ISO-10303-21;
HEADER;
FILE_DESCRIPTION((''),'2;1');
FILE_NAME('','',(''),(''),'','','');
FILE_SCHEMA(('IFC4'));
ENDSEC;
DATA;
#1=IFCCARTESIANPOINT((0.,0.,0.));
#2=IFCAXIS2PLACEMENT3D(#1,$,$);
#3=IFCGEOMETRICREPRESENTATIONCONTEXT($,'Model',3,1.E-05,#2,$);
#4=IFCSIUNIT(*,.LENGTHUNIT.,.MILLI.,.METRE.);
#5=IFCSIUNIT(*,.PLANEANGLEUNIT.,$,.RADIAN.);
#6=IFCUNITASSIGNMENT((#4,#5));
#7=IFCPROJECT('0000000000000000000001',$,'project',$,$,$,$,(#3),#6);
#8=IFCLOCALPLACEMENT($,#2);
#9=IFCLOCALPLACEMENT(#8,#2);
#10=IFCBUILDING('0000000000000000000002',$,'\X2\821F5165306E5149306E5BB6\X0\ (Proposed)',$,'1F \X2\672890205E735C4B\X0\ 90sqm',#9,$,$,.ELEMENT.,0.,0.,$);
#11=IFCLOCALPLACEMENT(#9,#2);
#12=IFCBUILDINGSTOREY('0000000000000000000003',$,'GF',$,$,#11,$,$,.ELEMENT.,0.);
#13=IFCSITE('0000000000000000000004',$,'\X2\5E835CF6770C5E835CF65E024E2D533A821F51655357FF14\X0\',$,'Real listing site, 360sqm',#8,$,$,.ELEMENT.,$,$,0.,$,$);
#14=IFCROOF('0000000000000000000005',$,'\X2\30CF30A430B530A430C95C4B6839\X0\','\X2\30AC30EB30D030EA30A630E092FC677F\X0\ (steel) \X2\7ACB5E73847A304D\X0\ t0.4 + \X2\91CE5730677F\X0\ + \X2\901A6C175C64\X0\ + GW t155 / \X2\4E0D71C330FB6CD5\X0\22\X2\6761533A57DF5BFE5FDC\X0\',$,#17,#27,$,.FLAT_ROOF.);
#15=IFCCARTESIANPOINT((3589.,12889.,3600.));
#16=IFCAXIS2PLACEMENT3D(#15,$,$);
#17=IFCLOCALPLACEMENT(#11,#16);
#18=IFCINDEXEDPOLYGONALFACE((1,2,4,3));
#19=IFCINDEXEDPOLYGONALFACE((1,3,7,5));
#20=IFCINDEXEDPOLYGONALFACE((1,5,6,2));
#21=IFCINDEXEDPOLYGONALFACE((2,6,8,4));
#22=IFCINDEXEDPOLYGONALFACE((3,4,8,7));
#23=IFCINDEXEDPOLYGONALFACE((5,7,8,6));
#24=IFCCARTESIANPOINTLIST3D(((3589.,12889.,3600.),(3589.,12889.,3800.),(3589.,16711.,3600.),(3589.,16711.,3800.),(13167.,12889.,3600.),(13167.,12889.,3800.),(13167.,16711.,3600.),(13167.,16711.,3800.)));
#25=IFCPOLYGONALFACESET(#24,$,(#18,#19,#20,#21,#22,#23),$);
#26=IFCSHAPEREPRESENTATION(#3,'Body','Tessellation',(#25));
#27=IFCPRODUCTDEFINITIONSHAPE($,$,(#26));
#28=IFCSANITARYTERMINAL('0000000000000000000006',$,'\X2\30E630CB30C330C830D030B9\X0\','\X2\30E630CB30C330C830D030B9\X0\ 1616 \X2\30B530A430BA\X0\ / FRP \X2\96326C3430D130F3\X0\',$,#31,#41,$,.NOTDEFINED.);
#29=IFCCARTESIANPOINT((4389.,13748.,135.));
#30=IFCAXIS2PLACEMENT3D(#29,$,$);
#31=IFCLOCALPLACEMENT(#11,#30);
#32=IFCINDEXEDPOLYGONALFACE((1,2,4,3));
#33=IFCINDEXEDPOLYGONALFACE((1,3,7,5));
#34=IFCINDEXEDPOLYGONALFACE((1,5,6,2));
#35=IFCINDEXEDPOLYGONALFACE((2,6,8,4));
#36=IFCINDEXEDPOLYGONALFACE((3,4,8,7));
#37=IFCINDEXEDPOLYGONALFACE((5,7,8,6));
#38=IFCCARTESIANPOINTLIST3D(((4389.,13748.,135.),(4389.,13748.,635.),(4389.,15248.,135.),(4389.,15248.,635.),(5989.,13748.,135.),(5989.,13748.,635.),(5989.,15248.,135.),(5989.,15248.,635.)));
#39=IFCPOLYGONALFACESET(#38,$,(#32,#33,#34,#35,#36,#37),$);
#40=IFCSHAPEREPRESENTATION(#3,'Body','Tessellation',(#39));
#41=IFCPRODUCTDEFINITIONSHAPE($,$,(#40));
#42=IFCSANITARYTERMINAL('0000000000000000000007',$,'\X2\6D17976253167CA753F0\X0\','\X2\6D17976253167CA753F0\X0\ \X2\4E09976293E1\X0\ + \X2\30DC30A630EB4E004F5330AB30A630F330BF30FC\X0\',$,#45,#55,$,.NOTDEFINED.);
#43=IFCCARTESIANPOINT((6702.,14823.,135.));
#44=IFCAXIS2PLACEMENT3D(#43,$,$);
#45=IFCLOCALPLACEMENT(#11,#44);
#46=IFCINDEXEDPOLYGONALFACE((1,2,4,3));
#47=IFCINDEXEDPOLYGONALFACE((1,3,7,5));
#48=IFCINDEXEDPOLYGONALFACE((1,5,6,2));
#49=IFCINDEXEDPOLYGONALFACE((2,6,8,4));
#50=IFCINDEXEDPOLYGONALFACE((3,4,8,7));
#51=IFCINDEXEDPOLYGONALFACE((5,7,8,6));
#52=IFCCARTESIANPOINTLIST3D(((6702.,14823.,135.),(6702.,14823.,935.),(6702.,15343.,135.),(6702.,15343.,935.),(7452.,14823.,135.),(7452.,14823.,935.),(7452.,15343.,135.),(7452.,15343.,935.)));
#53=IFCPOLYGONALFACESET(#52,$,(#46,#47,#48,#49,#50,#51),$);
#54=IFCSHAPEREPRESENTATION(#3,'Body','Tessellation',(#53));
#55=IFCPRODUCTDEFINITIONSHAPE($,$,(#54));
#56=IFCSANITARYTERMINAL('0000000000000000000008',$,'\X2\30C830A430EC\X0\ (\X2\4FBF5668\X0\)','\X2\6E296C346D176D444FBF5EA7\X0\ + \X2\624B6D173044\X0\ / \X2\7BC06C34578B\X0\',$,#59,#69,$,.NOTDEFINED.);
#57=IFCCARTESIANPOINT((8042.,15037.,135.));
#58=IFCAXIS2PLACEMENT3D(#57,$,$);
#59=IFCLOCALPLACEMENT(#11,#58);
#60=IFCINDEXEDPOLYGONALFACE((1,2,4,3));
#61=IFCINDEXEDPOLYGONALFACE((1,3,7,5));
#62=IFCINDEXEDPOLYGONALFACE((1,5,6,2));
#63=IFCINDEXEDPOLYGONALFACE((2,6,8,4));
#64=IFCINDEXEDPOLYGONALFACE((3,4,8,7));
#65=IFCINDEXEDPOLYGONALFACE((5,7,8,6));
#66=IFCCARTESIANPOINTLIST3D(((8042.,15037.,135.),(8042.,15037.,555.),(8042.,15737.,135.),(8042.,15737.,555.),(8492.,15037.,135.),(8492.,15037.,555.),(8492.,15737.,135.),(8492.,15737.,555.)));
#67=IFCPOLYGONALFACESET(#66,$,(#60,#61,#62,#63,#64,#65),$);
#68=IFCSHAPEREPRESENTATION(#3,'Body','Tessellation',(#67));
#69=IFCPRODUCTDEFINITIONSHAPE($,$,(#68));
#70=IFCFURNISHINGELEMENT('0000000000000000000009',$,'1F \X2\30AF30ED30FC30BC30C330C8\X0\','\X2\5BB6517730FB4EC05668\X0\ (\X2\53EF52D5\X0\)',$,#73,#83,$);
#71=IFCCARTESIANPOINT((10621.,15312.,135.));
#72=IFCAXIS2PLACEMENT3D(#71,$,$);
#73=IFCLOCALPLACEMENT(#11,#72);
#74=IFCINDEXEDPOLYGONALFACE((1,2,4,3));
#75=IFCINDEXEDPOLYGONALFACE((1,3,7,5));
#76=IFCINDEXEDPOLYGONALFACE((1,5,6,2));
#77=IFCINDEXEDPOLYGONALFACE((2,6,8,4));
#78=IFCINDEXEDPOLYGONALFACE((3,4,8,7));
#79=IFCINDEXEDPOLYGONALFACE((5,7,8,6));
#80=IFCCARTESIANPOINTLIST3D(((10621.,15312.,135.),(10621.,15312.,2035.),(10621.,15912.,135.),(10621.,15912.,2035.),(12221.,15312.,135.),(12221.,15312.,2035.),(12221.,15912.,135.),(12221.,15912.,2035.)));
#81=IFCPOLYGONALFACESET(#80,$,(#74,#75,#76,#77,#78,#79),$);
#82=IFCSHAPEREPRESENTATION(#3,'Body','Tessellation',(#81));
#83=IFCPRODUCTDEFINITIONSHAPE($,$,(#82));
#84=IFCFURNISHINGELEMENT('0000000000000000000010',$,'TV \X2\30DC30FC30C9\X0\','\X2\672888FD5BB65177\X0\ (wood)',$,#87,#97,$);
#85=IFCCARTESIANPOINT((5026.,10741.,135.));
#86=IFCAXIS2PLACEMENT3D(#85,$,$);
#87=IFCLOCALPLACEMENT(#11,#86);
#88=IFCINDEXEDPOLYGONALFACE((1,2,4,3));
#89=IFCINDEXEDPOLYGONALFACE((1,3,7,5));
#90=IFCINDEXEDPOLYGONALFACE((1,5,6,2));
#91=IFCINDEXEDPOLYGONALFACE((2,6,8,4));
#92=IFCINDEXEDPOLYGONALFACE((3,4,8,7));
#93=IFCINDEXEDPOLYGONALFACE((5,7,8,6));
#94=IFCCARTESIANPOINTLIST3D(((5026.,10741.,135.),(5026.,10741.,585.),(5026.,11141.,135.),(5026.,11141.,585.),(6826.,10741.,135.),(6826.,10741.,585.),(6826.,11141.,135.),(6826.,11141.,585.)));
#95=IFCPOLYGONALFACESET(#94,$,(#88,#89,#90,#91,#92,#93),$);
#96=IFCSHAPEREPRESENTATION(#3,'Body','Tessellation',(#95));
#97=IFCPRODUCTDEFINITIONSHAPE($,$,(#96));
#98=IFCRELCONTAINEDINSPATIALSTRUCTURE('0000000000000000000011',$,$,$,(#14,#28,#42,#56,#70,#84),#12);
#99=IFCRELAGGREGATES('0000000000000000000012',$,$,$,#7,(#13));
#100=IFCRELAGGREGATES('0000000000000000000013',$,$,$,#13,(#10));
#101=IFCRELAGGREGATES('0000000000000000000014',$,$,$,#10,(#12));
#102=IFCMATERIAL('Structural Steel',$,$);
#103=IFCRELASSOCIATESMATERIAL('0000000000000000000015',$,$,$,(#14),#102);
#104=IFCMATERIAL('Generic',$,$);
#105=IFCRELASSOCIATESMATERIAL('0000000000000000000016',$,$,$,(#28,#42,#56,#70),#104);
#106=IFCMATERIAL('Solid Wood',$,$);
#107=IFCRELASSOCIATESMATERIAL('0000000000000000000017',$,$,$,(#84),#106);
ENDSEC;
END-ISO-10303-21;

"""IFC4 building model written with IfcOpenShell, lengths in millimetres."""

from ifc_helpers import new_model, si_unit, frame, frame_2d, origin, place, context, project, spatial, rectangle, extrude, material, element, save


model = new_model("IFC4")

# Units and contexts
model_context = context("Model", 3, precision=1e-05, world=origin())
ifc_project = project(units=[si_unit("LENGTHUNIT", "METRE", prefix="MILLI"), si_unit("PLANEANGLEUNIT", "RADIAN")], contexts=[model_context])

# Site, building, storey
site_placement = place(None, origin())
site = spatial("IfcSite", under=ifc_project, at=site_placement, Name="広島県広島市中区舟入南４", ObjectType="Real listing site, 360sqm", CompositionType="ELEMENT", RefElevation=0.0)
building_placement = place(site_placement, origin())
building = spatial("IfcBuilding", under=site, at=building_placement, Name="舟入の光の家 (Proposed)", ObjectType="1F 木造平屋 90sqm", CompositionType="ELEMENT", ElevationOfRefHeight=0.0, ElevationOfTerrain=0.0)
storey_placement = place(building_placement, origin())
storey = spatial("IfcBuildingStorey", under=building, at=storey_placement, Name="GF", CompositionType="ELEMENT", Elevation=0.0)

# Shared definitions
ifc_material_1 = material(Name="Solid Wood")

# Roof
ifc_material_2 = material(Name="Structural Steel")
roof_placement = place(storey_placement, frame((3589.0, 12889.0, 3600.0)))
element("IfcRoof", 1, at=roof_placement, inside=storey, material=ifc_material_2, Name="ハイサイド屋根", Description="ガルバリウム鋼板 (steel) 立平葺き t0.4 + 野地板 + 通気層 + GW t155 / 不燃・法22条区域対応", PredefinedType="FLAT_ROOF", context=model_context, shape_type="SweptSolid", body=[
    extrude(rectangle(XDim=9578.0, YDim=3822.0, at=frame_2d((4789.0, 1911.0))), frame((3589.0, 12889.0, 3600.0)), (0.0, 0.0, 1.0), 200.0),
])

# Sanitary terminals
ifc_material_3 = material(Name="Generic")
sanitary_terminal_1_placement = place(storey_placement, frame((4389.0, 13748.0, 135.0)))
element("IfcSanitaryTerminal", 2, at=sanitary_terminal_1_placement, inside=storey, material=ifc_material_3, Name="ユニットバス", Description="ユニットバス 1616 サイズ / FRP 防水パン", PredefinedType="NOTDEFINED", context=model_context, shape_type="SweptSolid", body=[
    extrude(rectangle(XDim=1600.0, YDim=1500.0, at=frame_2d((800.0, 750.0))), frame((4389.0, 13748.0, 135.0)), (0.0, 0.0, 1.0), 500.0),
])
sanitary_terminal_2_placement = place(storey_placement, frame((6702.0, 14823.0, 135.0)))
element("IfcSanitaryTerminal", 3, at=sanitary_terminal_2_placement, inside=storey, material=ifc_material_3, Name="洗面化粧台", Description="洗面化粧台 三面鏡 + ボウル一体カウンター", PredefinedType="NOTDEFINED", context=model_context, shape_type="SweptSolid", body=[
    extrude(rectangle(XDim=750.0, YDim=520.0, at=frame_2d((375.0, 260.0))), frame((6702.0, 14823.0, 135.0)), (0.0, 0.0, 1.0), 800.0),
])
sanitary_terminal_3_placement = place(storey_placement, frame((8042.0, 15037.0, 135.0)))
element("IfcSanitaryTerminal", 4, at=sanitary_terminal_3_placement, inside=storey, material=ifc_material_3, Name="トイレ (便器)", Description="温水洗浄便座 + 手洗い / 節水型", PredefinedType="NOTDEFINED", context=model_context, shape_type="SweptSolid", body=[
    extrude(rectangle(XDim=450.0, YDim=700.0, at=frame_2d((225.0, 350.0))), frame((8042.0, 15037.0, 135.0)), (0.0, 0.0, 1.0), 420.0),
])

# Furnishing elements
furnishing_1_placement = place(storey_placement, frame((10621.0, 15312.0, 135.0)))
element("IfcFurnishingElement", 5, at=furnishing_1_placement, inside=storey, material=ifc_material_3, Name="1F クローゼット", Description="家具・什器 (可動)", context=model_context, shape_type="SweptSolid", body=[
    extrude(rectangle(XDim=1600.0, YDim=600.0, at=frame_2d((800.0, 300.0))), frame((10621.0, 15312.0, 135.0)), (0.0, 0.0, 1.0), 1900.0),
])
furnishing_2_placement = place(storey_placement, frame((5026.0, 10741.0, 135.0)))
element("IfcFurnishingElement", 6, at=furnishing_2_placement, inside=storey, material=ifc_material_1, Name="TV ボード", Description="木製家具 (wood)", context=model_context, shape_type="SweptSolid", body=[
    extrude(rectangle(XDim=1800.0, YDim=400.0, at=frame_2d((900.0, 200.0))), frame((5026.0, 10741.0, 135.0)), (0.0, 0.0, 1.0), 450.0),
])

save(model, "model.ifc")
